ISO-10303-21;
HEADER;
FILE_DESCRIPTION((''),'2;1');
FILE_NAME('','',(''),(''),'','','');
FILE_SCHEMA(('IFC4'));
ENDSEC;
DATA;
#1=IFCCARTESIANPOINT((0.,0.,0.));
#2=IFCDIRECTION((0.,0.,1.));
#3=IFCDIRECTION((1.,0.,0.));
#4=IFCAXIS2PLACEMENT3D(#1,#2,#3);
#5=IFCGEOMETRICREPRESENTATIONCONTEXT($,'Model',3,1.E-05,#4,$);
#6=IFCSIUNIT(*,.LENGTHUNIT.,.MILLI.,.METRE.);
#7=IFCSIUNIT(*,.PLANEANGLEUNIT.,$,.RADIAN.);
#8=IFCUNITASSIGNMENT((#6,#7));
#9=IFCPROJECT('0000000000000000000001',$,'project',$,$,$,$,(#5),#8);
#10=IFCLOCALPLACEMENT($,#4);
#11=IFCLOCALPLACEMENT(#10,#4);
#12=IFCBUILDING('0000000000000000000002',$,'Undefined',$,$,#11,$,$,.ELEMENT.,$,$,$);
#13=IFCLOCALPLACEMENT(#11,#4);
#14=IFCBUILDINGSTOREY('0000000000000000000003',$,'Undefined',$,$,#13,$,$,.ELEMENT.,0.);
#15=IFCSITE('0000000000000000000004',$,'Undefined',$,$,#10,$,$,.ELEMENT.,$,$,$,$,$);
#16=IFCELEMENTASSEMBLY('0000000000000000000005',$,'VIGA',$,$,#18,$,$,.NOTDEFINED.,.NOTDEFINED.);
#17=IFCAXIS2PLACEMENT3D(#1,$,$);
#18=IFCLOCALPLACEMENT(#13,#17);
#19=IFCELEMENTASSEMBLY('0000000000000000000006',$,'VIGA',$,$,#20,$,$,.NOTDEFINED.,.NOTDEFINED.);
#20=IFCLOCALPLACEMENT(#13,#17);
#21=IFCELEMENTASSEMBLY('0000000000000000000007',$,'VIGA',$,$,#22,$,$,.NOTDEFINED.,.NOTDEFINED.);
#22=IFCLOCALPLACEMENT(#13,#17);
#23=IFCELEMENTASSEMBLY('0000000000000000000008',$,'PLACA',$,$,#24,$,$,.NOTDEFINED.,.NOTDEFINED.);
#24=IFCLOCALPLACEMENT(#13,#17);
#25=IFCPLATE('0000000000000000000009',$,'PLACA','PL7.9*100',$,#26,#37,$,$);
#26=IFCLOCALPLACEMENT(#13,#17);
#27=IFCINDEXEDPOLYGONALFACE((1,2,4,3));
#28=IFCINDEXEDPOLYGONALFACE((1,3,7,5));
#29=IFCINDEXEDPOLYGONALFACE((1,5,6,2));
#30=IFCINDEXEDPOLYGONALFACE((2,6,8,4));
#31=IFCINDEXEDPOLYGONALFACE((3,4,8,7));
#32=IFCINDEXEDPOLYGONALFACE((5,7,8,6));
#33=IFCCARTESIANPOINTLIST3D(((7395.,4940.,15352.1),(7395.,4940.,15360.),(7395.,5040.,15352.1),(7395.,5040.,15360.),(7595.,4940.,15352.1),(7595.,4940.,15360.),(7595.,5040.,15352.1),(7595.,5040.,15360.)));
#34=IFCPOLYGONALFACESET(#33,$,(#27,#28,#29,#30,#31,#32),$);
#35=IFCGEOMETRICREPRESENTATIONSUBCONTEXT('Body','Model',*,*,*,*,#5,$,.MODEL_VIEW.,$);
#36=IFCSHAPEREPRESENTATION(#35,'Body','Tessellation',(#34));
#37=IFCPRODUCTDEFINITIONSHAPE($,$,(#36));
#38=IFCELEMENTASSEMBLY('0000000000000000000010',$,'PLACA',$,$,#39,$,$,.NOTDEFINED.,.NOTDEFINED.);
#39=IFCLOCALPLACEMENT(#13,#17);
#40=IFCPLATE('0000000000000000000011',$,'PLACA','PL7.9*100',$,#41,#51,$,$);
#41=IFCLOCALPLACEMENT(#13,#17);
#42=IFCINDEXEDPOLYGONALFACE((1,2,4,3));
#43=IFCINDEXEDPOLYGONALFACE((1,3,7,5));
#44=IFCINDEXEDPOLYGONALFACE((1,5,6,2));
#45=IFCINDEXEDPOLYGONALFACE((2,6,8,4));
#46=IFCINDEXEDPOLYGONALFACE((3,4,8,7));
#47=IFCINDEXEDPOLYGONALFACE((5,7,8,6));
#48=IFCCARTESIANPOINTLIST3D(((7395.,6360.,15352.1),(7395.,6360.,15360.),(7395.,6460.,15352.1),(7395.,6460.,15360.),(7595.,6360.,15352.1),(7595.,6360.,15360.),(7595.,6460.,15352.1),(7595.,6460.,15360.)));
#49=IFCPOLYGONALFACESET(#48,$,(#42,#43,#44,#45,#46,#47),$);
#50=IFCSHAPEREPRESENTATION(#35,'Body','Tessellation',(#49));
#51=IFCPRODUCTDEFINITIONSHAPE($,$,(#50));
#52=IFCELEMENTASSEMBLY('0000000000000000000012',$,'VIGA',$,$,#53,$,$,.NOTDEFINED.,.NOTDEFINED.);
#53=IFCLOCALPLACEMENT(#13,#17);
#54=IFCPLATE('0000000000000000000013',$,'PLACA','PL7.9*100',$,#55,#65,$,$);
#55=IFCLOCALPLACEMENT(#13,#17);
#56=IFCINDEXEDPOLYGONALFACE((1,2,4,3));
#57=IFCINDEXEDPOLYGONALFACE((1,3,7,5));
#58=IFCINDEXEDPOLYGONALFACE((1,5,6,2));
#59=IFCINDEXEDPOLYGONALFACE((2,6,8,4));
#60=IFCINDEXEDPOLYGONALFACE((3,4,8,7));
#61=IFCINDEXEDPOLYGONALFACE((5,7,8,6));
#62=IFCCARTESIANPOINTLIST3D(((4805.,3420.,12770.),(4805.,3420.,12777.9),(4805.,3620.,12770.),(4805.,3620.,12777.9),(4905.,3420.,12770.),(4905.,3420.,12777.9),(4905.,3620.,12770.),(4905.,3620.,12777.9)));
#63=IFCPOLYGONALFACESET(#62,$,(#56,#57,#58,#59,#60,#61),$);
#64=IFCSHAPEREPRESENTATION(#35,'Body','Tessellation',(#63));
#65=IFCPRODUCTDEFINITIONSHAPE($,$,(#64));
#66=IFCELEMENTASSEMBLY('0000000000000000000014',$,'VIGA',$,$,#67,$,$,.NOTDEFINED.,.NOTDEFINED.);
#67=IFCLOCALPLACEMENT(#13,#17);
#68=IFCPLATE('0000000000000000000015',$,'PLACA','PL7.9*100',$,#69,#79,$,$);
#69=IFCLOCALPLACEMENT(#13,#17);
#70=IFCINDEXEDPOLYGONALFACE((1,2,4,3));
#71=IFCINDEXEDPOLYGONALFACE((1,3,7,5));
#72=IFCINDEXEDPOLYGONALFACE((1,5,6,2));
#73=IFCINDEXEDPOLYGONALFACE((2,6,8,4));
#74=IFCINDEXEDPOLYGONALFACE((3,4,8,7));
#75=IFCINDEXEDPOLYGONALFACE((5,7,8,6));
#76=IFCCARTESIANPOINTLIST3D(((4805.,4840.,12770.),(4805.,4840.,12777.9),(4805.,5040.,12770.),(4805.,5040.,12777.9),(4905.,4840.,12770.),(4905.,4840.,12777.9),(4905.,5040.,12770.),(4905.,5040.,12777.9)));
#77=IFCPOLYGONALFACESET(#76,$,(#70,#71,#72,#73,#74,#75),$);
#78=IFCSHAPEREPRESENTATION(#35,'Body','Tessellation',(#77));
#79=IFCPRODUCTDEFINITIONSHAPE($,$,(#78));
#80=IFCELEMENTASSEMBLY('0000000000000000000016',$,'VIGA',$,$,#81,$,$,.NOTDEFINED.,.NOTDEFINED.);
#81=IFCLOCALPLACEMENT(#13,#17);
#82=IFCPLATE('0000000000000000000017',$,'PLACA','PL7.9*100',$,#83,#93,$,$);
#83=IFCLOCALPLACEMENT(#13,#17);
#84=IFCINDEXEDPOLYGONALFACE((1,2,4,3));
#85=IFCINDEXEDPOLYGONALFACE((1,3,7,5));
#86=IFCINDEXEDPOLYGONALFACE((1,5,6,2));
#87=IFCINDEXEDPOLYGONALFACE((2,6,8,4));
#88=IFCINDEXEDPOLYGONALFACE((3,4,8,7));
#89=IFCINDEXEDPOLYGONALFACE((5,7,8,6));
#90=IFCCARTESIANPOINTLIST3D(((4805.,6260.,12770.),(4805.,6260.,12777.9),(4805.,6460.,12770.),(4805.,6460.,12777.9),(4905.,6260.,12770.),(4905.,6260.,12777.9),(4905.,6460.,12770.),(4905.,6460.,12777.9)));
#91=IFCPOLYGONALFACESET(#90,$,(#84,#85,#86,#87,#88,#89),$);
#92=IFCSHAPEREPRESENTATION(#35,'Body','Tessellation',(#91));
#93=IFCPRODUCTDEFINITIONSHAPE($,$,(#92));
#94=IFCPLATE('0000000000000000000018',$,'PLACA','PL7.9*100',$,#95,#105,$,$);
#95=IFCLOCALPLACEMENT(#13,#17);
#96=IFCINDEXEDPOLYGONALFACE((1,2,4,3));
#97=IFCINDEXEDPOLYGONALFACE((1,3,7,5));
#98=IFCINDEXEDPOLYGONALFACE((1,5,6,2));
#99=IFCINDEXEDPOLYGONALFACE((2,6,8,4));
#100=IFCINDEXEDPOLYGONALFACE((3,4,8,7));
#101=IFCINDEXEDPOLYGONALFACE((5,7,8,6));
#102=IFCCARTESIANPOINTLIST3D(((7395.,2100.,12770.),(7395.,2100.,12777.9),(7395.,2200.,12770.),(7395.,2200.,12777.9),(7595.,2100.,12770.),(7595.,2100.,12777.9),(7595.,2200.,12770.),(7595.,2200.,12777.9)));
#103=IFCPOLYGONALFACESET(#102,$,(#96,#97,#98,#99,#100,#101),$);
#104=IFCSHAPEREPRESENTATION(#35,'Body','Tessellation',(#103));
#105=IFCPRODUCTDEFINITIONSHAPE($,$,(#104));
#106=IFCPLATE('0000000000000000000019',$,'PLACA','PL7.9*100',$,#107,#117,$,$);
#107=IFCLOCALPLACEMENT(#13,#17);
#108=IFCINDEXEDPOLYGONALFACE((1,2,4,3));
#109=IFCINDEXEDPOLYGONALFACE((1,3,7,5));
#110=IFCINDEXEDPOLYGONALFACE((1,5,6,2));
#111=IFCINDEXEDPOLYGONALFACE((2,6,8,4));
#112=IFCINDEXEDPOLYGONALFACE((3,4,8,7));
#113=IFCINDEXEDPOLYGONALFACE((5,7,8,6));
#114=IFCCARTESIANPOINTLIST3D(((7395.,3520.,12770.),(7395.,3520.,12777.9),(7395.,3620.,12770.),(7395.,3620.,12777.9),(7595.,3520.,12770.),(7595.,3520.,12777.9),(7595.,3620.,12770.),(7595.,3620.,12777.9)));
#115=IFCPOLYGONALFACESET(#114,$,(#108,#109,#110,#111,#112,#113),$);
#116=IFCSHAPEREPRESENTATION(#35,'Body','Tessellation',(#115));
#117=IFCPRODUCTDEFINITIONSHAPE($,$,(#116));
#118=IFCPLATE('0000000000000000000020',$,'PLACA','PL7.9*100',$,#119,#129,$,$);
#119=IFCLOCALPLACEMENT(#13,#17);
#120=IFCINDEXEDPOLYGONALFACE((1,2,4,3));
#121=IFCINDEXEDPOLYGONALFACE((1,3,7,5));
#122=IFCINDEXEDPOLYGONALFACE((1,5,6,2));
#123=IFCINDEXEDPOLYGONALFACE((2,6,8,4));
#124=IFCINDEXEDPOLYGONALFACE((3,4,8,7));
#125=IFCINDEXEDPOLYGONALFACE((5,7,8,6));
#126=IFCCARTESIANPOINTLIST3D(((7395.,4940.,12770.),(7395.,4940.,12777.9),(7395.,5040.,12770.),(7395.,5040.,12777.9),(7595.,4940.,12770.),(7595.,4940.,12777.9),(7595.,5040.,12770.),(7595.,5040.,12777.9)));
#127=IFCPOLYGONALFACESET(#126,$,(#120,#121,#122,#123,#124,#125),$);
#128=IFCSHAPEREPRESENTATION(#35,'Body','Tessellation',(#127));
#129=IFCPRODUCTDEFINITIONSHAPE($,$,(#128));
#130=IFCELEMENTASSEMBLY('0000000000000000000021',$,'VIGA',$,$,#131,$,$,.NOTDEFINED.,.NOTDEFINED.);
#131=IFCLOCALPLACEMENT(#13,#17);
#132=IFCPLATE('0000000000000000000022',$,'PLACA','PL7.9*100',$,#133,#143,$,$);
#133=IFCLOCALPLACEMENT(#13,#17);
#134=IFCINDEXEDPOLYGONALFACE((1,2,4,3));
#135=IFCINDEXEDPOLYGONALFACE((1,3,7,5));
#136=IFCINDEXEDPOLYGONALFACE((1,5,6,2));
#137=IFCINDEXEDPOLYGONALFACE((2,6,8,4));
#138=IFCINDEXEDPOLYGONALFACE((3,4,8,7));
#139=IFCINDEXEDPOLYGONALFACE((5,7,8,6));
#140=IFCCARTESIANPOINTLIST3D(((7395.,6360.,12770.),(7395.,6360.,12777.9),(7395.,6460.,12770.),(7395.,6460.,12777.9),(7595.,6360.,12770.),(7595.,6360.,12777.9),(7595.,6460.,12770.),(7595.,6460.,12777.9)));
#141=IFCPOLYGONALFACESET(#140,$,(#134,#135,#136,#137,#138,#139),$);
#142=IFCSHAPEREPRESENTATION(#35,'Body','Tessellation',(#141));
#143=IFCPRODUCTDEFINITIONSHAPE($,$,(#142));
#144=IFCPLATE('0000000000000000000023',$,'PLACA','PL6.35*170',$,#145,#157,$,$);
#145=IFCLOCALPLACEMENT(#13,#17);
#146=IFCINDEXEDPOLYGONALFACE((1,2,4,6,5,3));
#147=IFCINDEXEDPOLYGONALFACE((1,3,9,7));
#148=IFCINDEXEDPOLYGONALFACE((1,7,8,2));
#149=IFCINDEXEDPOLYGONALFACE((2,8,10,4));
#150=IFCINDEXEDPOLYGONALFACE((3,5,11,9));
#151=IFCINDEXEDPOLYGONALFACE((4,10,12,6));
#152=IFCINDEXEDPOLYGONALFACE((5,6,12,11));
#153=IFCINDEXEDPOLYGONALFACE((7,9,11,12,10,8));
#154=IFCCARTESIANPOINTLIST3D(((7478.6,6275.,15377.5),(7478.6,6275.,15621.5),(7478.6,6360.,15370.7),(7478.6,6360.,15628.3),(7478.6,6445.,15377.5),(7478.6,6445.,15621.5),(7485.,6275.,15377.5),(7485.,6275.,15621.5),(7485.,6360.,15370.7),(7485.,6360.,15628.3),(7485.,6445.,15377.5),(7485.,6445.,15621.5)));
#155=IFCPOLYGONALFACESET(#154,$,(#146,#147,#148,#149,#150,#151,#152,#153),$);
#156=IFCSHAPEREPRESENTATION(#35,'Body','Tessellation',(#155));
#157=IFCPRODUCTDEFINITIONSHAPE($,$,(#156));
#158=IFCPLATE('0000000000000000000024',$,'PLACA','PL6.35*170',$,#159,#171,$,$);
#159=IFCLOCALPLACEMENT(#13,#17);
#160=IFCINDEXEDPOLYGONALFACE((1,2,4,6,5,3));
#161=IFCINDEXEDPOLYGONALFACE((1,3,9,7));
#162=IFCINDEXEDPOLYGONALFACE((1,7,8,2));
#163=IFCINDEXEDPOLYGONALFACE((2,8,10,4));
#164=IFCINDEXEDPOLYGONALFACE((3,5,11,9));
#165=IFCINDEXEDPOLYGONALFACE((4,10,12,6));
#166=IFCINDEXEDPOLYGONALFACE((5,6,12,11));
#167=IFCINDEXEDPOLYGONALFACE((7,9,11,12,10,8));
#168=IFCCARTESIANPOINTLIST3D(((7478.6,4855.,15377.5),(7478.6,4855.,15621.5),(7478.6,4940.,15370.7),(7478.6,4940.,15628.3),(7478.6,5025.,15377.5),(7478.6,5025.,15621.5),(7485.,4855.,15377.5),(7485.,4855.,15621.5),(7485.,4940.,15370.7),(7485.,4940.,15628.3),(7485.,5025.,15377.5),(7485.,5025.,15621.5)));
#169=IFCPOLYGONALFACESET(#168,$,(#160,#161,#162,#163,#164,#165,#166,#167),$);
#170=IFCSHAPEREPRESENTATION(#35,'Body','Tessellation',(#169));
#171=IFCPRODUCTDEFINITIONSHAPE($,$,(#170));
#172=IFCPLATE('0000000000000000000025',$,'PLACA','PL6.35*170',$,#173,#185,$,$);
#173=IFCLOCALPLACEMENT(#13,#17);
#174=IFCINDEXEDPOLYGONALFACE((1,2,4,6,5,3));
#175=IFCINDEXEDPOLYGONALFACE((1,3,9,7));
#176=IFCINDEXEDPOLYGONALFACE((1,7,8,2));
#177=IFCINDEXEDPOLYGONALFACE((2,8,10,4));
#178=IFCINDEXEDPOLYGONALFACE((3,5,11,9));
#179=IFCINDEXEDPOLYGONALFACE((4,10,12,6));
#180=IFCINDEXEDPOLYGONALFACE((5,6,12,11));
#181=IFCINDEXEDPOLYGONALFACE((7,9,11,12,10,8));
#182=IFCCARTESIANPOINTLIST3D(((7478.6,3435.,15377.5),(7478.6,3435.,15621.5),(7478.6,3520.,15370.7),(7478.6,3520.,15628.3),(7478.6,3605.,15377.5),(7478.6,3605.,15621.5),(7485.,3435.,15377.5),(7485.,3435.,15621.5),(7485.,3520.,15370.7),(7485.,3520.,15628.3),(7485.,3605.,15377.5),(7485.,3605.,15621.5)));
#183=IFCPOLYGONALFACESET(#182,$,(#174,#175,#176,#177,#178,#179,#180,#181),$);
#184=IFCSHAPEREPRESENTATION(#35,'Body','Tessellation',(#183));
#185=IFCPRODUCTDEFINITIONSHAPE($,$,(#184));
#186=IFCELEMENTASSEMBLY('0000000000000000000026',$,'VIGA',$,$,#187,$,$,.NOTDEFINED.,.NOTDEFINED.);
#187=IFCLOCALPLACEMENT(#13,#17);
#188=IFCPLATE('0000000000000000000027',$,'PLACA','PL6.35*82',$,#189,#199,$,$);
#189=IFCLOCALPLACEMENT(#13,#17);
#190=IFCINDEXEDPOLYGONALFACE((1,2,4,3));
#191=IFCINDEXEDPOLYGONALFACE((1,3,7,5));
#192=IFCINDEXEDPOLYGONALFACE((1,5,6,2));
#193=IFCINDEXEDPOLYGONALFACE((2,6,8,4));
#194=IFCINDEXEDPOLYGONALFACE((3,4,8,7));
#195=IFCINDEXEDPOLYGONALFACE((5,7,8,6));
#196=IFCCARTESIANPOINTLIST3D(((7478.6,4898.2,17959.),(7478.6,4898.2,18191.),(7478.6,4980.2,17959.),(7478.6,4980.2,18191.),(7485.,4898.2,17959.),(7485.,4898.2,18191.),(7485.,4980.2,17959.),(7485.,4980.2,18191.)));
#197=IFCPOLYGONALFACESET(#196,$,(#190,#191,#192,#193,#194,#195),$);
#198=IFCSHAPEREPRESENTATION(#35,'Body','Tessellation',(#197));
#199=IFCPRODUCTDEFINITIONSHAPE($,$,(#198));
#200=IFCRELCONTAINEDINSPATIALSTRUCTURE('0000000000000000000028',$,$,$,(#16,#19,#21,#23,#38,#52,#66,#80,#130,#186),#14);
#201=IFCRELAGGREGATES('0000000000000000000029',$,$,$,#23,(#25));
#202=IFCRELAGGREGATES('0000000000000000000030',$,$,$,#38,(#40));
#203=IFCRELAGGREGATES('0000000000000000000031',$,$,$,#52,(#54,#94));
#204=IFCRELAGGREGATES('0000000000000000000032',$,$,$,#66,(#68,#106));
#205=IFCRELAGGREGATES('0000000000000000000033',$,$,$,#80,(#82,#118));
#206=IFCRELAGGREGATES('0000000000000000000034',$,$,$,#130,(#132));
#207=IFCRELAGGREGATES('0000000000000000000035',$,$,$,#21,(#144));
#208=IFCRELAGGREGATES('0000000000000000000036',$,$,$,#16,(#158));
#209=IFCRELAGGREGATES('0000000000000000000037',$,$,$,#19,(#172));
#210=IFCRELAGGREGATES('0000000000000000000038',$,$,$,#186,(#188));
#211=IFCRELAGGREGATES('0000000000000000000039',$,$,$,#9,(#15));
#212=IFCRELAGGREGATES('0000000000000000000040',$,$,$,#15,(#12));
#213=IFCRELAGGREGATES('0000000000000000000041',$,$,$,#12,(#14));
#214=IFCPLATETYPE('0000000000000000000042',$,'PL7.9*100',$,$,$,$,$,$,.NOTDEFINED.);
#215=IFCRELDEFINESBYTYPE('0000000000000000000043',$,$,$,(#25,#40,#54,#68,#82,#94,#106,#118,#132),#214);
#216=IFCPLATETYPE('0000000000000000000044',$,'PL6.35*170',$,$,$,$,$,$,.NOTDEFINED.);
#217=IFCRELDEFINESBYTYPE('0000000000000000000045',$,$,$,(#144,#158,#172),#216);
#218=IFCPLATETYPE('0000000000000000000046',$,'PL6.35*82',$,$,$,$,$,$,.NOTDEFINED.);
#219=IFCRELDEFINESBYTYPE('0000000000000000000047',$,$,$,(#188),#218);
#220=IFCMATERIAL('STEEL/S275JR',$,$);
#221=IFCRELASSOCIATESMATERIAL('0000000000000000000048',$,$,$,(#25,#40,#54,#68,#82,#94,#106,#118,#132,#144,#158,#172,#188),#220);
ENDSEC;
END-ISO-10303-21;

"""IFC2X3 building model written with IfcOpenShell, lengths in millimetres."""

from ifc_helpers import new_model, si_unit, frame, origin_with_axes, place, context, subcontext, project, spatial, polyline, outline, extrude, material, type_object, element, aggregate, save


model = new_model("IFC2X3")

# Units and contexts
model_context = context("Model", 3, precision=1e-05, world=origin_with_axes())
body_context = subcontext(model_context, "Body", "Model", "MODEL_VIEW")
ifc_project = project(units=[si_unit("LENGTHUNIT", "METRE", prefix="MILLI"), si_unit("PLANEANGLEUNIT", "RADIAN")], contexts=[model_context])

# Site, building, storey
site_placement = place(None, origin_with_axes())
site = spatial("IfcSite", under=ifc_project, at=site_placement, Name="Undefined", CompositionType="ELEMENT")
building_placement = place(site_placement, origin_with_axes())
building = spatial("IfcBuilding", under=site, at=building_placement, Name="Undefined", CompositionType="ELEMENT")
storey_placement = place(building_placement, origin_with_axes())
storey = spatial("IfcBuildingStorey", under=building, at=storey_placement, Name="Undefined", CompositionType="ELEMENT", Elevation=0.0)

# Shared definitions
ifc_material_1 = material(Name="STEEL/S275JR")

# Element assembly
assembly_1_placement = place(storey_placement, origin_with_axes())
assembly_1 = element("IfcElementAssembly", 1, at=assembly_1_placement, inside=storey, Name="VIGA", AssemblyPlace="NOTDEFINED", PredefinedType="NOTDEFINED")

# Shared definitions
plate_type_1 = type_object("IfcPlateType", Name="PL7.9*100", PredefinedType="NOTDEFINED")

# Element assembly
assembly_2_placement = place(storey_placement, origin_with_axes())
assembly_2 = element("IfcElementAssembly", 2, at=assembly_2_placement, inside=storey, Name="VIGA", AssemblyPlace="NOTDEFINED", PredefinedType="NOTDEFINED")

# Element assemblies, plates
assembly_3_placement = place(storey_placement, origin_with_axes())
assembly_3 = element("IfcElementAssembly", 3, at=assembly_3_placement, inside=storey, Name="VIGA", AssemblyPlace="NOTDEFINED", PredefinedType="NOTDEFINED")
assembly_4_placement = place(storey_placement, origin_with_axes())
assembly_4 = element("IfcElementAssembly", 4, at=assembly_4_placement, inside=storey, Name="PLACA", AssemblyPlace="NOTDEFINED", PredefinedType="NOTDEFINED")
plate_1_placement = place(assembly_4_placement, frame((7395.0, 5040.0, 15356.0), z_axis=(0.0, 0.0, 1.0), x_axis=(0.0, -1.0, 0.0)))
plate_1 = element("IfcPlate", 5, at=plate_1_placement, type_object=plate_type_1, material=ifc_material_1, Name="PLACA", Description="PL7.9*100", context=body_context, shape_type="SweptSolid", body=[
    extrude(outline(polyline([(0.0, 0.0), (100.0, 0.0), (100.0, 200.0), (0.0, 200.0), (0.0, 0.0)])), frame((0.0, 0.0, -4.0), z_axis=(0.0, 0.0, 1.0), x_axis=(1.0, 0.0, 0.0)), (0.0, 0.0, 1.0), 7.9),
])
aggregate(assembly_4, [plate_1])
assembly_5_placement = place(storey_placement, origin_with_axes())
assembly_5 = element("IfcElementAssembly", 6, at=assembly_5_placement, inside=storey, Name="PLACA", AssemblyPlace="NOTDEFINED", PredefinedType="NOTDEFINED")
plate_2_placement = place(assembly_5_placement, frame((7395.0, 6460.0, 15356.0), z_axis=(0.0, 0.0, 1.0), x_axis=(0.0, -1.0, 0.0)))
plate_2 = element("IfcPlate", 7, at=plate_2_placement, type_object=plate_type_1, material=ifc_material_1, Name="PLACA", Description="PL7.9*100", context=body_context, shape_type="SweptSolid", body=[
    extrude(outline(polyline([(0.0, 0.0), (100.0, 0.0), (100.0, 200.0), (0.0, 200.0), (0.0, 0.0)])), frame((0.0, 0.0, -4.0), z_axis=(0.0, 0.0, 1.0), x_axis=(1.0, 0.0, 0.0)), (0.0, 0.0, 1.0), 7.9),
])
aggregate(assembly_5, [plate_2])
assembly_6_placement = place(storey_placement, origin_with_axes())
assembly_6 = element("IfcElementAssembly", 8, at=assembly_6_placement, inside=storey, Name="VIGA", AssemblyPlace="NOTDEFINED", PredefinedType="NOTDEFINED")
plate_3_placement = place(assembly_6_placement, frame((4905.0, 3620.0, 12774.0), z_axis=(0.0, 0.0, 1.0), x_axis=(-1.0, 0.0, 0.0)))
plate_3 = element("IfcPlate", 9, at=plate_3_placement, type_object=plate_type_1, material=ifc_material_1, Name="PLACA", Description="PL7.9*100", context=body_context, shape_type="SweptSolid", body=[
    extrude(outline(polyline([(0.0, 0.0), (100.0, 0.0), (100.0, 200.0), (0.0, 200.0), (0.0, 0.0)])), frame((0.0, 0.0, -4.0), z_axis=(0.0, 0.0, 1.0), x_axis=(1.0, 0.0, 0.0)), (0.0, 0.0, 1.0), 7.9),
])
assembly_7_placement = place(storey_placement, origin_with_axes())
assembly_7 = element("IfcElementAssembly", 10, at=assembly_7_placement, inside=storey, Name="VIGA", AssemblyPlace="NOTDEFINED", PredefinedType="NOTDEFINED")
plate_4_placement = place(assembly_7_placement, frame((4905.0, 5040.0, 12774.0), z_axis=(0.0, 0.0, 1.0), x_axis=(-1.0, 0.0, 0.0)))
plate_4 = element("IfcPlate", 11, at=plate_4_placement, type_object=plate_type_1, material=ifc_material_1, Name="PLACA", Description="PL7.9*100", context=body_context, shape_type="SweptSolid", body=[
    extrude(outline(polyline([(0.0, 0.0), (100.0, 0.0), (100.0, 200.0), (0.0, 200.0), (0.0, 0.0)])), frame((0.0, 0.0, -4.0), z_axis=(0.0, 0.0, 1.0), x_axis=(1.0, 0.0, 0.0)), (0.0, 0.0, 1.0), 7.9),
])
assembly_8_placement = place(storey_placement, origin_with_axes())
assembly_8 = element("IfcElementAssembly", 12, at=assembly_8_placement, inside=storey, Name="VIGA", AssemblyPlace="NOTDEFINED", PredefinedType="NOTDEFINED")
plate_5_placement = place(assembly_8_placement, frame((4905.0, 6460.0, 12774.0), z_axis=(0.0, 0.0, 1.0), x_axis=(-1.0, 0.0, 0.0)))
plate_5 = element("IfcPlate", 13, at=plate_5_placement, type_object=plate_type_1, material=ifc_material_1, Name="PLACA", Description="PL7.9*100", context=body_context, shape_type="SweptSolid", body=[
    extrude(outline(polyline([(0.0, 0.0), (100.0, 0.0), (100.0, 200.0), (0.0, 200.0), (0.0, 0.0)])), frame((0.0, 0.0, -4.0), z_axis=(0.0, 0.0, 1.0), x_axis=(1.0, 0.0, 0.0)), (0.0, 0.0, 1.0), 7.9),
])

# Plates
plate_6_placement = place(assembly_6_placement, frame((7395.0, 2200.0, 12774.0), z_axis=(0.0, 0.0, 1.0), x_axis=(0.0, -1.0, 0.0)))
plate_6 = element("IfcPlate", 14, at=plate_6_placement, type_object=plate_type_1, material=ifc_material_1, Name="PLACA", Description="PL7.9*100", context=body_context, shape_type="SweptSolid", body=[
    extrude(outline(polyline([(0.0, 0.0), (100.0, 0.0), (100.0, 200.0), (0.0, 200.0), (0.0, 0.0)])), frame((0.0, 0.0, -4.0), z_axis=(0.0, 0.0, 1.0), x_axis=(1.0, 0.0, 0.0)), (0.0, 0.0, 1.0), 7.9),
])
aggregate(assembly_6, [plate_3, plate_6])
plate_7_placement = place(assembly_7_placement, frame((7395.0, 3620.0, 12774.0), z_axis=(0.0, 0.0, 1.0), x_axis=(0.0, -1.0, 0.0)))
plate_7 = element("IfcPlate", 15, at=plate_7_placement, type_object=plate_type_1, material=ifc_material_1, Name="PLACA", Description="PL7.9*100", context=body_context, shape_type="SweptSolid", body=[
    extrude(outline(polyline([(0.0, 0.0), (100.0, 0.0), (100.0, 200.0), (0.0, 200.0), (0.0, 0.0)])), frame((0.0, 0.0, -4.0), z_axis=(0.0, 0.0, 1.0), x_axis=(1.0, 0.0, 0.0)), (0.0, 0.0, 1.0), 7.9),
])
aggregate(assembly_7, [plate_4, plate_7])
plate_8_placement = place(assembly_8_placement, frame((7395.0, 5040.0, 12774.0), z_axis=(0.0, 0.0, 1.0), x_axis=(0.0, -1.0, 0.0)))
plate_8 = element("IfcPlate", 16, at=plate_8_placement, type_object=plate_type_1, material=ifc_material_1, Name="PLACA", Description="PL7.9*100", context=body_context, shape_type="SweptSolid", body=[
    extrude(outline(polyline([(0.0, 0.0), (100.0, 0.0), (100.0, 200.0), (0.0, 200.0), (0.0, 0.0)])), frame((0.0, 0.0, -4.0), z_axis=(0.0, 0.0, 1.0), x_axis=(1.0, 0.0, 0.0)), (0.0, 0.0, 1.0), 7.9),
])
aggregate(assembly_8, [plate_5, plate_8])

# Element assembly, plate
assembly_9_placement = place(storey_placement, origin_with_axes())
assembly_9 = element("IfcElementAssembly", 17, at=assembly_9_placement, inside=storey, Name="VIGA", AssemblyPlace="NOTDEFINED", PredefinedType="NOTDEFINED")
plate_9_placement = place(assembly_9_placement, frame((7395.0, 6460.0, 12774.0), z_axis=(0.0, 0.0, 1.0), x_axis=(0.0, -1.0, 0.0)))
plate_9 = element("IfcPlate", 18, at=plate_9_placement, type_object=plate_type_1, material=ifc_material_1, Name="PLACA", Description="PL7.9*100", context=body_context, shape_type="SweptSolid", body=[
    extrude(outline(polyline([(0.0, 0.0), (100.0, 0.0), (100.0, 200.0), (0.0, 200.0), (0.0, 0.0)])), frame((0.0, 0.0, -4.0), z_axis=(0.0, 0.0, 1.0), x_axis=(1.0, 0.0, 0.0)), (0.0, 0.0, 1.0), 7.9),
])
aggregate(assembly_9, [plate_9])

# Plates
plate_type_2 = type_object("IfcPlateType", Name="PL6.35*170", PredefinedType="NOTDEFINED")
plate_10_placement = place(assembly_3_placement, frame((7481.8, 6275.0, 15621.5), z_axis=(-1.0, 0.0, 0.0), x_axis=(0.0, 0.996815, 0.079745)))
plate_10 = element("IfcPlate", 19, at=plate_10_placement, type_object=plate_type_2, material=ifc_material_1, Name="PLACA", Description="PL6.35*170", context=body_context, shape_type="SweptSolid", body=[
    extrude(outline(polyline([(0.0, 0.0), (85.3, 0.0), (169.5, 13.6), (150.0, 256.8), (64.7, 256.8), (-19.5, 243.2), (0.0, 0.0)])), frame((0.0, 0.0, -3.2), z_axis=(0.0, 0.0, 1.0), x_axis=(1.0, 0.0, 0.0)), (0.0, 0.0, 1.0), 6.4),
])
aggregate(assembly_3, [plate_10])
plate_11_placement = place(assembly_1_placement, frame((7481.8, 4855.0, 15621.5), z_axis=(-1.0, 0.0, 0.0), x_axis=(0.0, 0.996815, 0.079745)))
plate_11 = element("IfcPlate", 20, at=plate_11_placement, type_object=plate_type_2, material=ifc_material_1, Name="PLACA", Description="PL6.35*170", context=body_context, shape_type="SweptSolid", body=[
    extrude(outline(polyline([(0.0, 0.0), (85.3, 0.0), (169.5, 13.6), (150.0, 256.8), (64.7, 256.8), (-19.5, 243.2), (0.0, 0.0)])), frame((0.0, 0.0, -3.2), z_axis=(0.0, 0.0, 1.0), x_axis=(1.0, 0.0, 0.0)), (0.0, 0.0, 1.0), 6.4),
])
aggregate(assembly_1, [plate_11])
plate_12_placement = place(assembly_2_placement, frame((7481.8, 3435.0, 15621.5), z_axis=(-1.0, 0.0, 0.0), x_axis=(0.0, 0.996815, 0.079745)))
plate_12 = element("IfcPlate", 21, at=plate_12_placement, type_object=plate_type_2, material=ifc_material_1, Name="PLACA", Description="PL6.35*170", context=body_context, shape_type="SweptSolid", body=[
    extrude(outline(polyline([(0.0, 0.0), (85.3, 0.0), (169.5, 13.6), (150.0, 256.8), (64.7, 256.8), (-19.5, 243.2), (0.0, 0.0)])), frame((0.0, 0.0, -3.2), z_axis=(0.0, 0.0, 1.0), x_axis=(1.0, 0.0, 0.0)), (0.0, 0.0, 1.0), 6.4),
])
aggregate(assembly_2, [plate_12])

# Element assembly, plate
assembly_10_placement = place(storey_placement, origin_with_axes())
assembly_10 = element("IfcElementAssembly", 22, at=assembly_10_placement, inside=storey, Name="VIGA", AssemblyPlace="NOTDEFINED", PredefinedType="NOTDEFINED")
plate_type_3 = type_object("IfcPlateType", Name="PL6.35*82", PredefinedType="NOTDEFINED")
plate_13_placement = place(assembly_10_placement, frame((7481.8, 4898.2, 18191.0), z_axis=(-1.0, 0.0, 0.0), x_axis=(0.0, 1.0, 0.0)))
plate_13 = element("IfcPlate", 23, at=plate_13_placement, type_object=plate_type_3, material=ifc_material_1, Name="PLACA", Description="PL6.35*82", context=body_context, shape_type="SweptSolid", body=[
    extrude(outline(polyline([(0.0, 0.0), (82.0, 0.0), (82.0, 232.0), (0.0, 232.0), (0.0, 0.0)])), frame((0.0, 0.0, -3.2), z_axis=(0.0, 0.0, 1.0), x_axis=(1.0, 0.0, 0.0)), (0.0, 0.0, 1.0), 6.4),
])
aggregate(assembly_10, [plate_13])

save(model, "model.ifc")
